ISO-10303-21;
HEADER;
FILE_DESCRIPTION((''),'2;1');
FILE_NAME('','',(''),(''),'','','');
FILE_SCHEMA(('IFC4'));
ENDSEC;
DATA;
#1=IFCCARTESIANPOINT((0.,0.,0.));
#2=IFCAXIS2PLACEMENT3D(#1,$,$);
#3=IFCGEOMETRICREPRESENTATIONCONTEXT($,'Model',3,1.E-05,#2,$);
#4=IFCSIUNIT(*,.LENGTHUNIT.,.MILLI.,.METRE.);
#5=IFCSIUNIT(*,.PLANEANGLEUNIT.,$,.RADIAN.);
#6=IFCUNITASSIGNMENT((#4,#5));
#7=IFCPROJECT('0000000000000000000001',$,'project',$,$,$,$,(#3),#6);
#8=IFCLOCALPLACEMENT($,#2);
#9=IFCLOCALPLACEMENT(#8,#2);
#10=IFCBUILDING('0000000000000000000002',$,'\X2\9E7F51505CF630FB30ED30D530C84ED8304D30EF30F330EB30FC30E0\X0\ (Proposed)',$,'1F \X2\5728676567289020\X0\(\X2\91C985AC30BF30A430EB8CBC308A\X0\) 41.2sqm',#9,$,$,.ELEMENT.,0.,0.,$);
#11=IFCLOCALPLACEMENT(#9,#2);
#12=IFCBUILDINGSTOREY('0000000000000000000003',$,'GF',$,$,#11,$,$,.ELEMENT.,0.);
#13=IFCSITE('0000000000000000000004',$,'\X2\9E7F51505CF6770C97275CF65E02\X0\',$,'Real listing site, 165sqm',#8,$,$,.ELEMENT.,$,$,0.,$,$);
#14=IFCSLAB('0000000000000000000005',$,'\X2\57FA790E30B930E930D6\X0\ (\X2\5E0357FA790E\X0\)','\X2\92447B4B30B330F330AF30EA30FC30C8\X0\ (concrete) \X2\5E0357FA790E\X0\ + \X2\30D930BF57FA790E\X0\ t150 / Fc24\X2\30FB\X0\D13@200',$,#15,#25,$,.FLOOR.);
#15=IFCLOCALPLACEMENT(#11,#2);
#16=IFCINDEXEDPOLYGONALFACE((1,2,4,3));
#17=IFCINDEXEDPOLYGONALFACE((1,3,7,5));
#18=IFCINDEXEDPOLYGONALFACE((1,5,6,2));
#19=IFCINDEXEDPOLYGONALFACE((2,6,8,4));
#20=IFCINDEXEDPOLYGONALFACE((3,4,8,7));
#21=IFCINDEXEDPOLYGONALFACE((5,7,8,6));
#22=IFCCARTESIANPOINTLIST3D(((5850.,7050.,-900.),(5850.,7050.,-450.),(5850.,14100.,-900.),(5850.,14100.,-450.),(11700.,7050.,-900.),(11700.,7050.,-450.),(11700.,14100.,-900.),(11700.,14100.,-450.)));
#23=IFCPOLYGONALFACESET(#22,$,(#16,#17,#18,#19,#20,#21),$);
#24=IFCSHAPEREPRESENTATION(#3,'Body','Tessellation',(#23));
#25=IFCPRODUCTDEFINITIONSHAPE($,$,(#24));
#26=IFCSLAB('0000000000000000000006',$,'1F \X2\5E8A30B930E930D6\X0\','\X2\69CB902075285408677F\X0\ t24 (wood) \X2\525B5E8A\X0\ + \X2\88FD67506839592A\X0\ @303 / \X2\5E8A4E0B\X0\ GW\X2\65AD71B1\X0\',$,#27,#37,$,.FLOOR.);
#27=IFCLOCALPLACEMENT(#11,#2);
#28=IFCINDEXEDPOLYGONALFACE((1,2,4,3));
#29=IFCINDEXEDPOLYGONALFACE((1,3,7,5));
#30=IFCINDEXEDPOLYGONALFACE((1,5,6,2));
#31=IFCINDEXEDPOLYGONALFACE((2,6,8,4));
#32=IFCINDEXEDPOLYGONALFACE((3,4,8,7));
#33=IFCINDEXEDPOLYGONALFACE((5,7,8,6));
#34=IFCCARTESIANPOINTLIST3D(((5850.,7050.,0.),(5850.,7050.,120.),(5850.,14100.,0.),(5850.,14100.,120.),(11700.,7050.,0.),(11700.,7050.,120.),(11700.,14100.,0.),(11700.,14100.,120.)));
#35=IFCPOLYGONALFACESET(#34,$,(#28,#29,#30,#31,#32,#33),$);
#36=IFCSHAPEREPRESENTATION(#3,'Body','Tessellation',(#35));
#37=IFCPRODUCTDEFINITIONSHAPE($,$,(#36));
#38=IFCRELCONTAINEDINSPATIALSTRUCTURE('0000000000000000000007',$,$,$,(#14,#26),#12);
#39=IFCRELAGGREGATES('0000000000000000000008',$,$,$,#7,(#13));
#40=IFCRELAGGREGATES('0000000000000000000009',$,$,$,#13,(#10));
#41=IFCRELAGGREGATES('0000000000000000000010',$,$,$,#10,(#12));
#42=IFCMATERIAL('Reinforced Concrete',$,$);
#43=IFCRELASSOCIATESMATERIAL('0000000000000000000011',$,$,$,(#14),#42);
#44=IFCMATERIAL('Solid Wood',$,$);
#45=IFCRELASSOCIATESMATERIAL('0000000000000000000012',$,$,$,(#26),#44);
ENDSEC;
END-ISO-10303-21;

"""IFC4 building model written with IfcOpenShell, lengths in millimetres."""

from ifc_helpers import new_model, si_unit, frame, frame_2d, origin, place, context, project, spatial, rectangle, extrude, material, element, save


model = new_model("IFC4")

# Units and contexts
model_context = context("Model", 3, precision=1e-05, world=origin())
ifc_project = project(units=[si_unit("LENGTHUNIT", "METRE", prefix="MILLI"), si_unit("PLANEANGLEUNIT", "RADIAN")], contexts=[model_context])

# Site, building, storey
site_placement = place(None, origin())
site = spatial("IfcSite", under=ifc_project, at=site_placement, Name="鹿児島県霧島市", ObjectType="Real listing site, 165sqm", CompositionType="ELEMENT", RefElevation=0.0)
building_placement = place(site_placement, origin())
building = spatial("IfcBuilding", under=site, at=building_placement, Name="鹿児島・ロフト付きワンルーム (Proposed)", ObjectType="1F 在来木造(釉薬タイル貼り) 41.2sqm", CompositionType="ELEMENT", ElevationOfRefHeight=0.0, ElevationOfTerrain=0.0)
storey_placement = place(building_placement, origin())
storey = spatial("IfcBuildingStorey", under=building, at=storey_placement, Name="GF", CompositionType="ELEMENT", Elevation=0.0)

# Shared definitions
ifc_material_1 = material(Name="Solid Wood")

# Slabs
ifc_material_2 = material(Name="Reinforced Concrete")
slab_1_placement = place(storey_placement, frame((2925.0, 3525.0, -450.0)))
element("IfcSlab", 1, at=slab_1_placement, inside=storey, material=ifc_material_2, Name="基礎スラブ (布基礎)", Description="鉄筋コンクリート (concrete) 布基礎 + ベタ基礎 t150 / Fc24・D13@200", PredefinedType="FLOOR", context=model_context, shape_type="SweptSolid", body=[
    extrude(rectangle(XDim=5850.0, YDim=7050.0, at=frame_2d((2925.0, 3525.0))), frame((2925.0, 3525.0, -450.0)), (0.0, 0.0, 1.0), 450.0),
])
slab_2_placement = place(storey_placement, frame((2925.0, 3525.0, 0.0)))
element("IfcSlab", 2, at=slab_2_placement, inside=storey, material=ifc_material_1, Name="1F 床スラブ", Description="構造用合板 t24 (wood) 剛床 + 製材根太 @303 / 床下 GW断熱", PredefinedType="FLOOR", context=model_context, shape_type="SweptSolid", body=[
    extrude(rectangle(XDim=5850.0, YDim=7050.0, at=frame_2d((2925.0, 3525.0))), frame((2925.0, 3525.0, 0.0)), (0.0, 0.0, 1.0), 120.0),
])

save(model, "model.ifc")
